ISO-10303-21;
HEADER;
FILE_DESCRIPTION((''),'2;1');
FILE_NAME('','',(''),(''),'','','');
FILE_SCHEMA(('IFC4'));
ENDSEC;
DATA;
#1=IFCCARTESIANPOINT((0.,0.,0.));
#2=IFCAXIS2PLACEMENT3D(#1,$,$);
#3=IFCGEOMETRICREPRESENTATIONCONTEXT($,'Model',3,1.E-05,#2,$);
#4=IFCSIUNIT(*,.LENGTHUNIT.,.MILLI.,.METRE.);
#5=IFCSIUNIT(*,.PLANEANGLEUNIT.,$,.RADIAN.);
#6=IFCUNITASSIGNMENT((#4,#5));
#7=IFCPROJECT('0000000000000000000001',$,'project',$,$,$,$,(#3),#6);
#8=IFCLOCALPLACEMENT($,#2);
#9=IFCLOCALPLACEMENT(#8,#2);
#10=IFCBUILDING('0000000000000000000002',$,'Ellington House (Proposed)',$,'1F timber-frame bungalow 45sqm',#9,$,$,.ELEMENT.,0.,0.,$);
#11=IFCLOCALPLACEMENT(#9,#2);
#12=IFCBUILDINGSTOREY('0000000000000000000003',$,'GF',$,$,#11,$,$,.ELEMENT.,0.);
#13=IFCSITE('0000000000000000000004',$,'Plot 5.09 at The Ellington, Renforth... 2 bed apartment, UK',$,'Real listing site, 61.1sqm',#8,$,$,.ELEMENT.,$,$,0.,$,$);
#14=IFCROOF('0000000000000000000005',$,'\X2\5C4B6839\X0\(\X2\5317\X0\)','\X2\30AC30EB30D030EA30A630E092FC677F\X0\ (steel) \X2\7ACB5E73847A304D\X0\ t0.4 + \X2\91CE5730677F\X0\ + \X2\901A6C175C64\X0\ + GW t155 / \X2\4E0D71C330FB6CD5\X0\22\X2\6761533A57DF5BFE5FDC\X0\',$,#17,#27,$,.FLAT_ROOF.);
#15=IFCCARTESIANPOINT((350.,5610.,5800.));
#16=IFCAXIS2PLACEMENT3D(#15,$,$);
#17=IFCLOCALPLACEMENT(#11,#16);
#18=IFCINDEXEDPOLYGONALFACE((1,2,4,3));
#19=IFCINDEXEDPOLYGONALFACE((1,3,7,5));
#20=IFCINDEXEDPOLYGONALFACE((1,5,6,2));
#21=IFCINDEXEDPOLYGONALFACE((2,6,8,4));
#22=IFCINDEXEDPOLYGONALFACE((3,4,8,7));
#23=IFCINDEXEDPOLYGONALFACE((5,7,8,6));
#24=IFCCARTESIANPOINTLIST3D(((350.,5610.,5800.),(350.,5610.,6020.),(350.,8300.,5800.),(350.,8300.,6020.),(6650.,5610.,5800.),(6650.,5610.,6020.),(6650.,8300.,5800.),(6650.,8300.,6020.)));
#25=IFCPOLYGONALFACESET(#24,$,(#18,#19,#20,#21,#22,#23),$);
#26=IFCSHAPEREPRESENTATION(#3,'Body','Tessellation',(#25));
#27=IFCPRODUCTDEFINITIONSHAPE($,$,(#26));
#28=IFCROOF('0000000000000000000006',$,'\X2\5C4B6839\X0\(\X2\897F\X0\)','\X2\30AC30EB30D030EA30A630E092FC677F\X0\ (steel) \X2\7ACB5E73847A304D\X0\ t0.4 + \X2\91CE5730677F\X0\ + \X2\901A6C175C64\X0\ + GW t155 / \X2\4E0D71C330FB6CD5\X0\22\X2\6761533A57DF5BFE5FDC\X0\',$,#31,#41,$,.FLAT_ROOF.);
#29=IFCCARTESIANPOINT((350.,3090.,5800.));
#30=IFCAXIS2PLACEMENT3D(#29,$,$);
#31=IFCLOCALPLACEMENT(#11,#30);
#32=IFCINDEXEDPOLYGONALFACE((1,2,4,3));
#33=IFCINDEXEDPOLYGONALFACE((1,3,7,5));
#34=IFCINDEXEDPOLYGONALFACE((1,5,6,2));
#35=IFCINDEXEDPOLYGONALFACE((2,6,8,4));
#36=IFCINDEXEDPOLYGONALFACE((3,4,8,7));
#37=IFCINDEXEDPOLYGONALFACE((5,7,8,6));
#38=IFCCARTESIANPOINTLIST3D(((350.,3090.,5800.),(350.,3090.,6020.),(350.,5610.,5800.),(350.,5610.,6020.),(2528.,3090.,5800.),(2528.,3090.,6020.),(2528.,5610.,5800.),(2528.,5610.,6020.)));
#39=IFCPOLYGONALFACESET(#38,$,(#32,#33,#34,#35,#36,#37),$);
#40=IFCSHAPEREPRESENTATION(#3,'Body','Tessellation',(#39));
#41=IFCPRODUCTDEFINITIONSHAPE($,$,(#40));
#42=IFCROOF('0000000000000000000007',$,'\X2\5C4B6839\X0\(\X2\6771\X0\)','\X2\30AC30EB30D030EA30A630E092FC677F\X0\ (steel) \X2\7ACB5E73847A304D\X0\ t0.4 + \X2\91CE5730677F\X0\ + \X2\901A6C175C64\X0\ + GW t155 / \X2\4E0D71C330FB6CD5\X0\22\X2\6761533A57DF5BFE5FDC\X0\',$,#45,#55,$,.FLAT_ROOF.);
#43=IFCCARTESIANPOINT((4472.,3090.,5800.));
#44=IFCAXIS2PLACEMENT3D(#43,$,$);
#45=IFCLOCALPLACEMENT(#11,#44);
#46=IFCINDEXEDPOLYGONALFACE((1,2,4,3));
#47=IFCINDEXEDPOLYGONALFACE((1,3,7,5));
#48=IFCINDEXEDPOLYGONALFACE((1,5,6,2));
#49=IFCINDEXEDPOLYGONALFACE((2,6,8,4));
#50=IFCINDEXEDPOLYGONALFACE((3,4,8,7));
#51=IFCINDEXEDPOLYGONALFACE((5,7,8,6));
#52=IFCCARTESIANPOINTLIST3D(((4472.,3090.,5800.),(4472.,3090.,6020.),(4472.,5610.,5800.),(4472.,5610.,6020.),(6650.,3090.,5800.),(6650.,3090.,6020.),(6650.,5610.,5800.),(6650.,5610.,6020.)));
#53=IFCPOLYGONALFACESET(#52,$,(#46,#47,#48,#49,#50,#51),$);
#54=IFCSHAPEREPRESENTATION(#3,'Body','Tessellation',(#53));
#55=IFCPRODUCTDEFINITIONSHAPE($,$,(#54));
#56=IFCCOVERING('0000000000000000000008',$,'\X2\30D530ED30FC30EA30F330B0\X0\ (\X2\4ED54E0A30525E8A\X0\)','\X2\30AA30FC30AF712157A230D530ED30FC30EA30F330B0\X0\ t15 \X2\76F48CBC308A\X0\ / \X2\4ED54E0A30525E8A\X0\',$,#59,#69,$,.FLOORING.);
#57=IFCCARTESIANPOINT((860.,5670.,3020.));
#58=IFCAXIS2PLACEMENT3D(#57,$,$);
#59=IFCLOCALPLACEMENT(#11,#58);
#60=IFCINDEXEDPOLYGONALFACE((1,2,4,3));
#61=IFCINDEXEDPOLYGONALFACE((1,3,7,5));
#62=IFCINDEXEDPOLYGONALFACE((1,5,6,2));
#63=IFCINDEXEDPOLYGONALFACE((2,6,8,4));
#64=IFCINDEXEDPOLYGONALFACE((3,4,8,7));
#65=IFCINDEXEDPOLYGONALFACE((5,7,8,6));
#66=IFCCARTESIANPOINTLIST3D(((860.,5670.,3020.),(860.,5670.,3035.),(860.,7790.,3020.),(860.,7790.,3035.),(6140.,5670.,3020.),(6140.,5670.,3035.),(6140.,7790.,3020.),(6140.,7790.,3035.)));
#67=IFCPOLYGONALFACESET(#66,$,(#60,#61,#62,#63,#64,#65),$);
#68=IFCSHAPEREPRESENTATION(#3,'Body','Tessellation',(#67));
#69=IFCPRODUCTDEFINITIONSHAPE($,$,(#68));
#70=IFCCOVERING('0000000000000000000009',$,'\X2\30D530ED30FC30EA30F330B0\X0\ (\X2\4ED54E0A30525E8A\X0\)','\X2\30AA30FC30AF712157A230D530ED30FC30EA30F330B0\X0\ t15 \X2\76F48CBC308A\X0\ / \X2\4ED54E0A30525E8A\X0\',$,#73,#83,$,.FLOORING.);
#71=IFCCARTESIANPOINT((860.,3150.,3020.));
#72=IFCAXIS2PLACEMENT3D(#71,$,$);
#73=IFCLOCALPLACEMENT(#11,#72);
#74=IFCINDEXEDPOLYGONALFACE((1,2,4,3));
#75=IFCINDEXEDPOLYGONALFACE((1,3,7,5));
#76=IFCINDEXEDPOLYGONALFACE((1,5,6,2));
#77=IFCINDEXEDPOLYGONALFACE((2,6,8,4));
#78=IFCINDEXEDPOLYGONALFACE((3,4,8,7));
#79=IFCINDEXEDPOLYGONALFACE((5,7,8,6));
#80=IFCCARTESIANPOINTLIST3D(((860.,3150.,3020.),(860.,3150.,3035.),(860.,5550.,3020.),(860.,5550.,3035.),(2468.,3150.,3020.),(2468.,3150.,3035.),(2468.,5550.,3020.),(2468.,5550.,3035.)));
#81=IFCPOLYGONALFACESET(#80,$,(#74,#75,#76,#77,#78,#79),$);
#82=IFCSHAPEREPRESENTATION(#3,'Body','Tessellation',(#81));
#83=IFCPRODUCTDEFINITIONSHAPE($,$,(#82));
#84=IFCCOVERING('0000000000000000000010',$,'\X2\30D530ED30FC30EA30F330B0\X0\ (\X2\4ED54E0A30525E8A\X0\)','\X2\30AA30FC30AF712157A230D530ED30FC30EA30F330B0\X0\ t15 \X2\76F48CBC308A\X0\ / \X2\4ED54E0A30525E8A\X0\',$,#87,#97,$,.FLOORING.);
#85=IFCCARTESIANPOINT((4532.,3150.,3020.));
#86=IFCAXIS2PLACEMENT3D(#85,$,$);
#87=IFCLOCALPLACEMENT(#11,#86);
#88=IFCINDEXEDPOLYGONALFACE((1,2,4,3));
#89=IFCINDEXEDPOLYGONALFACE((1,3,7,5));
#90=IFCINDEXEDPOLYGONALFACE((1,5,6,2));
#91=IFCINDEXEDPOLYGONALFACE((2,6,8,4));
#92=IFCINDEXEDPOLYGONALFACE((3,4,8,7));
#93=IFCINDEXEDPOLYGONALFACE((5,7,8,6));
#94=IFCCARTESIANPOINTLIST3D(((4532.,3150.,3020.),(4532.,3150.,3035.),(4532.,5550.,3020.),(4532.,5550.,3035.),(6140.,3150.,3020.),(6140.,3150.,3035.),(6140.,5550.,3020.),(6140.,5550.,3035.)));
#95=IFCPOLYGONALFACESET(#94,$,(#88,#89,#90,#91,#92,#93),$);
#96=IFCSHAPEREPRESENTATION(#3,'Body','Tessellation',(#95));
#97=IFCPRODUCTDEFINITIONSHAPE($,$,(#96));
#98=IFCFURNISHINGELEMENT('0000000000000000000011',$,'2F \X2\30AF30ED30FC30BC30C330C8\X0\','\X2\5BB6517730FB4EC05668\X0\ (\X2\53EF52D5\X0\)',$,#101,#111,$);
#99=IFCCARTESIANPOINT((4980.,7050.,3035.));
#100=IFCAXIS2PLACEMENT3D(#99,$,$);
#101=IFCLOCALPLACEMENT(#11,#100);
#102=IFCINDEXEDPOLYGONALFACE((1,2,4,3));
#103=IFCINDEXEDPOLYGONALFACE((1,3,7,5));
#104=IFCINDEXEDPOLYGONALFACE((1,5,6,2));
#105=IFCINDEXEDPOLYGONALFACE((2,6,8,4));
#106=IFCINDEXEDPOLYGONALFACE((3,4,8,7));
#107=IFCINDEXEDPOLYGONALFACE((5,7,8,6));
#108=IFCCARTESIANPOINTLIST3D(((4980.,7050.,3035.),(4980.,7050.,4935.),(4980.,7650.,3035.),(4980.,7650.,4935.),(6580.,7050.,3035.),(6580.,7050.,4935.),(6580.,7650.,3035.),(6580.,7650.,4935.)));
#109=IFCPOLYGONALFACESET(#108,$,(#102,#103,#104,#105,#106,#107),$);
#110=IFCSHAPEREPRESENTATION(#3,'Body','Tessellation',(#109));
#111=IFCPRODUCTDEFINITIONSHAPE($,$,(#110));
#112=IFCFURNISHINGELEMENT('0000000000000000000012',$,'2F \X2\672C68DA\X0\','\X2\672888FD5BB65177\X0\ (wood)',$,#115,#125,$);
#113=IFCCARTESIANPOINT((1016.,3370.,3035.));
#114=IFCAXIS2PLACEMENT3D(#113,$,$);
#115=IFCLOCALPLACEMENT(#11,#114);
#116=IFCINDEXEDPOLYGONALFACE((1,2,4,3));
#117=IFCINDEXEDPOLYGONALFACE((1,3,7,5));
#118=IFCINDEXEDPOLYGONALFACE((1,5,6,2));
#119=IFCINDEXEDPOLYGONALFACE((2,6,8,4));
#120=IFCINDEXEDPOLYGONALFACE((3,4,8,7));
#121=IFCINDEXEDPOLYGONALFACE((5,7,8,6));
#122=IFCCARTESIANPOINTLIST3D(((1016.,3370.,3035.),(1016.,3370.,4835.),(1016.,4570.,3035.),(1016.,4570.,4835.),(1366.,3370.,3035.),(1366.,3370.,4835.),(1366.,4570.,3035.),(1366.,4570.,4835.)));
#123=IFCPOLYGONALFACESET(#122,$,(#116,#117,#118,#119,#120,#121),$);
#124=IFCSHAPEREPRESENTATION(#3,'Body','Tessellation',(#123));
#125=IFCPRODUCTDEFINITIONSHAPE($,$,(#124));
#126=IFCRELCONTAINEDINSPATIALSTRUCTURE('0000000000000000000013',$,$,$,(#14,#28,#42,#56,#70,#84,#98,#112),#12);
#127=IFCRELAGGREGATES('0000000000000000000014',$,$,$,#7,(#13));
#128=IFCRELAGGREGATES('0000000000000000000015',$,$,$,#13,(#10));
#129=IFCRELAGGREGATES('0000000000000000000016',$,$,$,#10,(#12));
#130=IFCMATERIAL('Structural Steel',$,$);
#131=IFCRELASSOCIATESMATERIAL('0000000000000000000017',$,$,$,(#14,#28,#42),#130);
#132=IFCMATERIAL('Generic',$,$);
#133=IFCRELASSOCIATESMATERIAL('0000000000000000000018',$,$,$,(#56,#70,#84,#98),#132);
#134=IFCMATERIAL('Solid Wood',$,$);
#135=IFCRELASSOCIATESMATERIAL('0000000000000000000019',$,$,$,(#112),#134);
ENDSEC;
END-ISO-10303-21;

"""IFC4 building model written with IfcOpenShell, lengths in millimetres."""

from ifc_helpers import new_model, si_unit, frame, frame_2d, origin, place, context, project, spatial, rectangle, extrude, material, element, save


model = new_model("IFC4")

# Units and contexts
model_context = context("Model", 3, precision=1e-05, world=origin())
ifc_project = project(units=[si_unit("LENGTHUNIT", "METRE", prefix="MILLI"), si_unit("PLANEANGLEUNIT", "RADIAN")], contexts=[model_context])

# Site, building, storey
site_placement = place(None, origin())
site = spatial("IfcSite", under=ifc_project, at=site_placement, Name="Plot 5.09 at The Ellington, Renforth... 2 bed apartment, UK", ObjectType="Real listing site, 61.1sqm", CompositionType="ELEMENT", RefElevation=0.0)
building_placement = place(site_placement, origin())
building = spatial("IfcBuilding", under=site, at=building_placement, Name="Ellington House (Proposed)", ObjectType="1F timber-frame bungalow 45sqm", CompositionType="ELEMENT", ElevationOfRefHeight=0.0, ElevationOfTerrain=0.0)
storey_placement = place(building_placement, origin())
storey = spatial("IfcBuildingStorey", under=building, at=storey_placement, Name="GF", CompositionType="ELEMENT", Elevation=0.0)

# Shared definitions
ifc_material_1 = material(Name="Solid Wood")

# Shared definitions
ifc_material_2 = material(Name="Generic")

# Roofs
ifc_material_3 = material(Name="Structural Steel")
for number, where, name in (
    (1, (350.0, 5610.0, 5800.0), "屋根(北)"),
):
    element("IfcRoof", number, at=place(storey_placement, frame(where)), inside=storey, material=ifc_material_3, Name=name, Description="ガルバリウム鋼板 (steel) 立平葺き t0.4 + 野地板 + 通気層 + GW t155 / 不燃・法22条区域対応", PredefinedType="FLAT_ROOF", context=model_context, shape_type="SweptSolid", body=[
        extrude(rectangle(XDim=6300.0, YDim=2690.0, at=frame_2d((3150.0, 1345.0))), frame((350.0, 5610.0, 5800.0)), (0.0, 0.0, 1.0), 220.0),
    ])
roof_1_placement = place(storey_placement, frame((350.0, 3090.0, 5800.0)))
element("IfcRoof", 2, at=roof_1_placement, inside=storey, material=ifc_material_3, Name="屋根(西)", Description="ガルバリウム鋼板 (steel) 立平葺き t0.4 + 野地板 + 通気層 + GW t155 / 不燃・法22条区域対応", PredefinedType="FLAT_ROOF", context=model_context, shape_type="SweptSolid", body=[
    extrude(rectangle(XDim=2178.0, YDim=2520.0, at=frame_2d((1089.0, 1260.0))), frame((350.0, 3090.0, 5800.0)), (0.0, 0.0, 1.0), 220.0),
])
roof_2_placement = place(storey_placement, frame((4472.0, 3090.0, 5800.0)))
element("IfcRoof", 3, at=roof_2_placement, inside=storey, material=ifc_material_3, Name="屋根(東)", Description="ガルバリウム鋼板 (steel) 立平葺き t0.4 + 野地板 + 通気層 + GW t155 / 不燃・法22条区域対応", PredefinedType="FLAT_ROOF", context=model_context, shape_type="SweptSolid", body=[
    extrude(rectangle(XDim=2178.0, YDim=2520.0, at=frame_2d((1089.0, 1260.0))), frame((4472.0, 3090.0, 5800.0)), (0.0, 0.0, 1.0), 220.0),
])

# Coverings
covering_1_placement = place(storey_placement, frame((860.0, 5670.0, 3020.0)))
element("IfcCovering", 4, at=covering_1_placement, inside=storey, material=ifc_material_2, Name="フローリング (仕上げ床)", Description="オーク無垢フローリング t15 直貼り / 仕上げ床", PredefinedType="FLOORING", context=model_context, shape_type="SweptSolid", body=[
    extrude(rectangle(XDim=5280.0, YDim=2120.0, at=frame_2d((2640.0, 1060.0))), frame((860.0, 5670.0, 3020.0)), (0.0, 0.0, 1.0), 15.0),
])
covering_2_placement = place(storey_placement, frame((860.0, 3150.0, 3020.0)))
element("IfcCovering", 5, at=covering_2_placement, inside=storey, material=ifc_material_2, Name="フローリング (仕上げ床)", Description="オーク無垢フローリング t15 直貼り / 仕上げ床", PredefinedType="FLOORING", context=model_context, shape_type="SweptSolid", body=[
    extrude(rectangle(XDim=1608.0, YDim=2400.0, at=frame_2d((804.0, 1200.0))), frame((860.0, 3150.0, 3020.0)), (0.0, 0.0, 1.0), 15.0),
])
covering_3_placement = place(storey_placement, frame((4532.0, 3150.0, 3020.0)))
element("IfcCovering", 6, at=covering_3_placement, inside=storey, material=ifc_material_2, Name="フローリング (仕上げ床)", Description="オーク無垢フローリング t15 直貼り / 仕上げ床", PredefinedType="FLOORING", context=model_context, shape_type="SweptSolid", body=[
    extrude(rectangle(XDim=1608.0, YDim=2400.0, at=frame_2d((804.0, 1200.0))), frame((4532.0, 3150.0, 3020.0)), (0.0, 0.0, 1.0), 15.0),
])

# Furnishing elements
furnishing_1_placement = place(storey_placement, frame((4980.0, 7050.0, 3035.0)))
element("IfcFurnishingElement", 7, at=furnishing_1_placement, inside=storey, material=ifc_material_2, Name="2F クローゼット", Description="家具・什器 (可動)", context=model_context, shape_type="SweptSolid", body=[
    extrude(rectangle(XDim=1600.0, YDim=600.0, at=frame_2d((800.0, 300.0))), frame((4980.0, 7050.0, 3035.0)), (0.0, 0.0, 1.0), 1900.0),
])
furnishing_2_placement = place(storey_placement, frame((1016.0, 3370.0, 3035.0)))
element("IfcFurnishingElement", 8, at=furnishing_2_placement, inside=storey, material=ifc_material_1, Name="2F 本棚", Description="木製家具 (wood)", context=model_context, shape_type="SweptSolid", body=[
    extrude(rectangle(XDim=350.0, YDim=1200.0, at=frame_2d((175.0, 600.0))), frame((1016.0, 3370.0, 3035.0)), (0.0, 0.0, 1.0), 1800.0),
])

save(model, "model.ifc")
